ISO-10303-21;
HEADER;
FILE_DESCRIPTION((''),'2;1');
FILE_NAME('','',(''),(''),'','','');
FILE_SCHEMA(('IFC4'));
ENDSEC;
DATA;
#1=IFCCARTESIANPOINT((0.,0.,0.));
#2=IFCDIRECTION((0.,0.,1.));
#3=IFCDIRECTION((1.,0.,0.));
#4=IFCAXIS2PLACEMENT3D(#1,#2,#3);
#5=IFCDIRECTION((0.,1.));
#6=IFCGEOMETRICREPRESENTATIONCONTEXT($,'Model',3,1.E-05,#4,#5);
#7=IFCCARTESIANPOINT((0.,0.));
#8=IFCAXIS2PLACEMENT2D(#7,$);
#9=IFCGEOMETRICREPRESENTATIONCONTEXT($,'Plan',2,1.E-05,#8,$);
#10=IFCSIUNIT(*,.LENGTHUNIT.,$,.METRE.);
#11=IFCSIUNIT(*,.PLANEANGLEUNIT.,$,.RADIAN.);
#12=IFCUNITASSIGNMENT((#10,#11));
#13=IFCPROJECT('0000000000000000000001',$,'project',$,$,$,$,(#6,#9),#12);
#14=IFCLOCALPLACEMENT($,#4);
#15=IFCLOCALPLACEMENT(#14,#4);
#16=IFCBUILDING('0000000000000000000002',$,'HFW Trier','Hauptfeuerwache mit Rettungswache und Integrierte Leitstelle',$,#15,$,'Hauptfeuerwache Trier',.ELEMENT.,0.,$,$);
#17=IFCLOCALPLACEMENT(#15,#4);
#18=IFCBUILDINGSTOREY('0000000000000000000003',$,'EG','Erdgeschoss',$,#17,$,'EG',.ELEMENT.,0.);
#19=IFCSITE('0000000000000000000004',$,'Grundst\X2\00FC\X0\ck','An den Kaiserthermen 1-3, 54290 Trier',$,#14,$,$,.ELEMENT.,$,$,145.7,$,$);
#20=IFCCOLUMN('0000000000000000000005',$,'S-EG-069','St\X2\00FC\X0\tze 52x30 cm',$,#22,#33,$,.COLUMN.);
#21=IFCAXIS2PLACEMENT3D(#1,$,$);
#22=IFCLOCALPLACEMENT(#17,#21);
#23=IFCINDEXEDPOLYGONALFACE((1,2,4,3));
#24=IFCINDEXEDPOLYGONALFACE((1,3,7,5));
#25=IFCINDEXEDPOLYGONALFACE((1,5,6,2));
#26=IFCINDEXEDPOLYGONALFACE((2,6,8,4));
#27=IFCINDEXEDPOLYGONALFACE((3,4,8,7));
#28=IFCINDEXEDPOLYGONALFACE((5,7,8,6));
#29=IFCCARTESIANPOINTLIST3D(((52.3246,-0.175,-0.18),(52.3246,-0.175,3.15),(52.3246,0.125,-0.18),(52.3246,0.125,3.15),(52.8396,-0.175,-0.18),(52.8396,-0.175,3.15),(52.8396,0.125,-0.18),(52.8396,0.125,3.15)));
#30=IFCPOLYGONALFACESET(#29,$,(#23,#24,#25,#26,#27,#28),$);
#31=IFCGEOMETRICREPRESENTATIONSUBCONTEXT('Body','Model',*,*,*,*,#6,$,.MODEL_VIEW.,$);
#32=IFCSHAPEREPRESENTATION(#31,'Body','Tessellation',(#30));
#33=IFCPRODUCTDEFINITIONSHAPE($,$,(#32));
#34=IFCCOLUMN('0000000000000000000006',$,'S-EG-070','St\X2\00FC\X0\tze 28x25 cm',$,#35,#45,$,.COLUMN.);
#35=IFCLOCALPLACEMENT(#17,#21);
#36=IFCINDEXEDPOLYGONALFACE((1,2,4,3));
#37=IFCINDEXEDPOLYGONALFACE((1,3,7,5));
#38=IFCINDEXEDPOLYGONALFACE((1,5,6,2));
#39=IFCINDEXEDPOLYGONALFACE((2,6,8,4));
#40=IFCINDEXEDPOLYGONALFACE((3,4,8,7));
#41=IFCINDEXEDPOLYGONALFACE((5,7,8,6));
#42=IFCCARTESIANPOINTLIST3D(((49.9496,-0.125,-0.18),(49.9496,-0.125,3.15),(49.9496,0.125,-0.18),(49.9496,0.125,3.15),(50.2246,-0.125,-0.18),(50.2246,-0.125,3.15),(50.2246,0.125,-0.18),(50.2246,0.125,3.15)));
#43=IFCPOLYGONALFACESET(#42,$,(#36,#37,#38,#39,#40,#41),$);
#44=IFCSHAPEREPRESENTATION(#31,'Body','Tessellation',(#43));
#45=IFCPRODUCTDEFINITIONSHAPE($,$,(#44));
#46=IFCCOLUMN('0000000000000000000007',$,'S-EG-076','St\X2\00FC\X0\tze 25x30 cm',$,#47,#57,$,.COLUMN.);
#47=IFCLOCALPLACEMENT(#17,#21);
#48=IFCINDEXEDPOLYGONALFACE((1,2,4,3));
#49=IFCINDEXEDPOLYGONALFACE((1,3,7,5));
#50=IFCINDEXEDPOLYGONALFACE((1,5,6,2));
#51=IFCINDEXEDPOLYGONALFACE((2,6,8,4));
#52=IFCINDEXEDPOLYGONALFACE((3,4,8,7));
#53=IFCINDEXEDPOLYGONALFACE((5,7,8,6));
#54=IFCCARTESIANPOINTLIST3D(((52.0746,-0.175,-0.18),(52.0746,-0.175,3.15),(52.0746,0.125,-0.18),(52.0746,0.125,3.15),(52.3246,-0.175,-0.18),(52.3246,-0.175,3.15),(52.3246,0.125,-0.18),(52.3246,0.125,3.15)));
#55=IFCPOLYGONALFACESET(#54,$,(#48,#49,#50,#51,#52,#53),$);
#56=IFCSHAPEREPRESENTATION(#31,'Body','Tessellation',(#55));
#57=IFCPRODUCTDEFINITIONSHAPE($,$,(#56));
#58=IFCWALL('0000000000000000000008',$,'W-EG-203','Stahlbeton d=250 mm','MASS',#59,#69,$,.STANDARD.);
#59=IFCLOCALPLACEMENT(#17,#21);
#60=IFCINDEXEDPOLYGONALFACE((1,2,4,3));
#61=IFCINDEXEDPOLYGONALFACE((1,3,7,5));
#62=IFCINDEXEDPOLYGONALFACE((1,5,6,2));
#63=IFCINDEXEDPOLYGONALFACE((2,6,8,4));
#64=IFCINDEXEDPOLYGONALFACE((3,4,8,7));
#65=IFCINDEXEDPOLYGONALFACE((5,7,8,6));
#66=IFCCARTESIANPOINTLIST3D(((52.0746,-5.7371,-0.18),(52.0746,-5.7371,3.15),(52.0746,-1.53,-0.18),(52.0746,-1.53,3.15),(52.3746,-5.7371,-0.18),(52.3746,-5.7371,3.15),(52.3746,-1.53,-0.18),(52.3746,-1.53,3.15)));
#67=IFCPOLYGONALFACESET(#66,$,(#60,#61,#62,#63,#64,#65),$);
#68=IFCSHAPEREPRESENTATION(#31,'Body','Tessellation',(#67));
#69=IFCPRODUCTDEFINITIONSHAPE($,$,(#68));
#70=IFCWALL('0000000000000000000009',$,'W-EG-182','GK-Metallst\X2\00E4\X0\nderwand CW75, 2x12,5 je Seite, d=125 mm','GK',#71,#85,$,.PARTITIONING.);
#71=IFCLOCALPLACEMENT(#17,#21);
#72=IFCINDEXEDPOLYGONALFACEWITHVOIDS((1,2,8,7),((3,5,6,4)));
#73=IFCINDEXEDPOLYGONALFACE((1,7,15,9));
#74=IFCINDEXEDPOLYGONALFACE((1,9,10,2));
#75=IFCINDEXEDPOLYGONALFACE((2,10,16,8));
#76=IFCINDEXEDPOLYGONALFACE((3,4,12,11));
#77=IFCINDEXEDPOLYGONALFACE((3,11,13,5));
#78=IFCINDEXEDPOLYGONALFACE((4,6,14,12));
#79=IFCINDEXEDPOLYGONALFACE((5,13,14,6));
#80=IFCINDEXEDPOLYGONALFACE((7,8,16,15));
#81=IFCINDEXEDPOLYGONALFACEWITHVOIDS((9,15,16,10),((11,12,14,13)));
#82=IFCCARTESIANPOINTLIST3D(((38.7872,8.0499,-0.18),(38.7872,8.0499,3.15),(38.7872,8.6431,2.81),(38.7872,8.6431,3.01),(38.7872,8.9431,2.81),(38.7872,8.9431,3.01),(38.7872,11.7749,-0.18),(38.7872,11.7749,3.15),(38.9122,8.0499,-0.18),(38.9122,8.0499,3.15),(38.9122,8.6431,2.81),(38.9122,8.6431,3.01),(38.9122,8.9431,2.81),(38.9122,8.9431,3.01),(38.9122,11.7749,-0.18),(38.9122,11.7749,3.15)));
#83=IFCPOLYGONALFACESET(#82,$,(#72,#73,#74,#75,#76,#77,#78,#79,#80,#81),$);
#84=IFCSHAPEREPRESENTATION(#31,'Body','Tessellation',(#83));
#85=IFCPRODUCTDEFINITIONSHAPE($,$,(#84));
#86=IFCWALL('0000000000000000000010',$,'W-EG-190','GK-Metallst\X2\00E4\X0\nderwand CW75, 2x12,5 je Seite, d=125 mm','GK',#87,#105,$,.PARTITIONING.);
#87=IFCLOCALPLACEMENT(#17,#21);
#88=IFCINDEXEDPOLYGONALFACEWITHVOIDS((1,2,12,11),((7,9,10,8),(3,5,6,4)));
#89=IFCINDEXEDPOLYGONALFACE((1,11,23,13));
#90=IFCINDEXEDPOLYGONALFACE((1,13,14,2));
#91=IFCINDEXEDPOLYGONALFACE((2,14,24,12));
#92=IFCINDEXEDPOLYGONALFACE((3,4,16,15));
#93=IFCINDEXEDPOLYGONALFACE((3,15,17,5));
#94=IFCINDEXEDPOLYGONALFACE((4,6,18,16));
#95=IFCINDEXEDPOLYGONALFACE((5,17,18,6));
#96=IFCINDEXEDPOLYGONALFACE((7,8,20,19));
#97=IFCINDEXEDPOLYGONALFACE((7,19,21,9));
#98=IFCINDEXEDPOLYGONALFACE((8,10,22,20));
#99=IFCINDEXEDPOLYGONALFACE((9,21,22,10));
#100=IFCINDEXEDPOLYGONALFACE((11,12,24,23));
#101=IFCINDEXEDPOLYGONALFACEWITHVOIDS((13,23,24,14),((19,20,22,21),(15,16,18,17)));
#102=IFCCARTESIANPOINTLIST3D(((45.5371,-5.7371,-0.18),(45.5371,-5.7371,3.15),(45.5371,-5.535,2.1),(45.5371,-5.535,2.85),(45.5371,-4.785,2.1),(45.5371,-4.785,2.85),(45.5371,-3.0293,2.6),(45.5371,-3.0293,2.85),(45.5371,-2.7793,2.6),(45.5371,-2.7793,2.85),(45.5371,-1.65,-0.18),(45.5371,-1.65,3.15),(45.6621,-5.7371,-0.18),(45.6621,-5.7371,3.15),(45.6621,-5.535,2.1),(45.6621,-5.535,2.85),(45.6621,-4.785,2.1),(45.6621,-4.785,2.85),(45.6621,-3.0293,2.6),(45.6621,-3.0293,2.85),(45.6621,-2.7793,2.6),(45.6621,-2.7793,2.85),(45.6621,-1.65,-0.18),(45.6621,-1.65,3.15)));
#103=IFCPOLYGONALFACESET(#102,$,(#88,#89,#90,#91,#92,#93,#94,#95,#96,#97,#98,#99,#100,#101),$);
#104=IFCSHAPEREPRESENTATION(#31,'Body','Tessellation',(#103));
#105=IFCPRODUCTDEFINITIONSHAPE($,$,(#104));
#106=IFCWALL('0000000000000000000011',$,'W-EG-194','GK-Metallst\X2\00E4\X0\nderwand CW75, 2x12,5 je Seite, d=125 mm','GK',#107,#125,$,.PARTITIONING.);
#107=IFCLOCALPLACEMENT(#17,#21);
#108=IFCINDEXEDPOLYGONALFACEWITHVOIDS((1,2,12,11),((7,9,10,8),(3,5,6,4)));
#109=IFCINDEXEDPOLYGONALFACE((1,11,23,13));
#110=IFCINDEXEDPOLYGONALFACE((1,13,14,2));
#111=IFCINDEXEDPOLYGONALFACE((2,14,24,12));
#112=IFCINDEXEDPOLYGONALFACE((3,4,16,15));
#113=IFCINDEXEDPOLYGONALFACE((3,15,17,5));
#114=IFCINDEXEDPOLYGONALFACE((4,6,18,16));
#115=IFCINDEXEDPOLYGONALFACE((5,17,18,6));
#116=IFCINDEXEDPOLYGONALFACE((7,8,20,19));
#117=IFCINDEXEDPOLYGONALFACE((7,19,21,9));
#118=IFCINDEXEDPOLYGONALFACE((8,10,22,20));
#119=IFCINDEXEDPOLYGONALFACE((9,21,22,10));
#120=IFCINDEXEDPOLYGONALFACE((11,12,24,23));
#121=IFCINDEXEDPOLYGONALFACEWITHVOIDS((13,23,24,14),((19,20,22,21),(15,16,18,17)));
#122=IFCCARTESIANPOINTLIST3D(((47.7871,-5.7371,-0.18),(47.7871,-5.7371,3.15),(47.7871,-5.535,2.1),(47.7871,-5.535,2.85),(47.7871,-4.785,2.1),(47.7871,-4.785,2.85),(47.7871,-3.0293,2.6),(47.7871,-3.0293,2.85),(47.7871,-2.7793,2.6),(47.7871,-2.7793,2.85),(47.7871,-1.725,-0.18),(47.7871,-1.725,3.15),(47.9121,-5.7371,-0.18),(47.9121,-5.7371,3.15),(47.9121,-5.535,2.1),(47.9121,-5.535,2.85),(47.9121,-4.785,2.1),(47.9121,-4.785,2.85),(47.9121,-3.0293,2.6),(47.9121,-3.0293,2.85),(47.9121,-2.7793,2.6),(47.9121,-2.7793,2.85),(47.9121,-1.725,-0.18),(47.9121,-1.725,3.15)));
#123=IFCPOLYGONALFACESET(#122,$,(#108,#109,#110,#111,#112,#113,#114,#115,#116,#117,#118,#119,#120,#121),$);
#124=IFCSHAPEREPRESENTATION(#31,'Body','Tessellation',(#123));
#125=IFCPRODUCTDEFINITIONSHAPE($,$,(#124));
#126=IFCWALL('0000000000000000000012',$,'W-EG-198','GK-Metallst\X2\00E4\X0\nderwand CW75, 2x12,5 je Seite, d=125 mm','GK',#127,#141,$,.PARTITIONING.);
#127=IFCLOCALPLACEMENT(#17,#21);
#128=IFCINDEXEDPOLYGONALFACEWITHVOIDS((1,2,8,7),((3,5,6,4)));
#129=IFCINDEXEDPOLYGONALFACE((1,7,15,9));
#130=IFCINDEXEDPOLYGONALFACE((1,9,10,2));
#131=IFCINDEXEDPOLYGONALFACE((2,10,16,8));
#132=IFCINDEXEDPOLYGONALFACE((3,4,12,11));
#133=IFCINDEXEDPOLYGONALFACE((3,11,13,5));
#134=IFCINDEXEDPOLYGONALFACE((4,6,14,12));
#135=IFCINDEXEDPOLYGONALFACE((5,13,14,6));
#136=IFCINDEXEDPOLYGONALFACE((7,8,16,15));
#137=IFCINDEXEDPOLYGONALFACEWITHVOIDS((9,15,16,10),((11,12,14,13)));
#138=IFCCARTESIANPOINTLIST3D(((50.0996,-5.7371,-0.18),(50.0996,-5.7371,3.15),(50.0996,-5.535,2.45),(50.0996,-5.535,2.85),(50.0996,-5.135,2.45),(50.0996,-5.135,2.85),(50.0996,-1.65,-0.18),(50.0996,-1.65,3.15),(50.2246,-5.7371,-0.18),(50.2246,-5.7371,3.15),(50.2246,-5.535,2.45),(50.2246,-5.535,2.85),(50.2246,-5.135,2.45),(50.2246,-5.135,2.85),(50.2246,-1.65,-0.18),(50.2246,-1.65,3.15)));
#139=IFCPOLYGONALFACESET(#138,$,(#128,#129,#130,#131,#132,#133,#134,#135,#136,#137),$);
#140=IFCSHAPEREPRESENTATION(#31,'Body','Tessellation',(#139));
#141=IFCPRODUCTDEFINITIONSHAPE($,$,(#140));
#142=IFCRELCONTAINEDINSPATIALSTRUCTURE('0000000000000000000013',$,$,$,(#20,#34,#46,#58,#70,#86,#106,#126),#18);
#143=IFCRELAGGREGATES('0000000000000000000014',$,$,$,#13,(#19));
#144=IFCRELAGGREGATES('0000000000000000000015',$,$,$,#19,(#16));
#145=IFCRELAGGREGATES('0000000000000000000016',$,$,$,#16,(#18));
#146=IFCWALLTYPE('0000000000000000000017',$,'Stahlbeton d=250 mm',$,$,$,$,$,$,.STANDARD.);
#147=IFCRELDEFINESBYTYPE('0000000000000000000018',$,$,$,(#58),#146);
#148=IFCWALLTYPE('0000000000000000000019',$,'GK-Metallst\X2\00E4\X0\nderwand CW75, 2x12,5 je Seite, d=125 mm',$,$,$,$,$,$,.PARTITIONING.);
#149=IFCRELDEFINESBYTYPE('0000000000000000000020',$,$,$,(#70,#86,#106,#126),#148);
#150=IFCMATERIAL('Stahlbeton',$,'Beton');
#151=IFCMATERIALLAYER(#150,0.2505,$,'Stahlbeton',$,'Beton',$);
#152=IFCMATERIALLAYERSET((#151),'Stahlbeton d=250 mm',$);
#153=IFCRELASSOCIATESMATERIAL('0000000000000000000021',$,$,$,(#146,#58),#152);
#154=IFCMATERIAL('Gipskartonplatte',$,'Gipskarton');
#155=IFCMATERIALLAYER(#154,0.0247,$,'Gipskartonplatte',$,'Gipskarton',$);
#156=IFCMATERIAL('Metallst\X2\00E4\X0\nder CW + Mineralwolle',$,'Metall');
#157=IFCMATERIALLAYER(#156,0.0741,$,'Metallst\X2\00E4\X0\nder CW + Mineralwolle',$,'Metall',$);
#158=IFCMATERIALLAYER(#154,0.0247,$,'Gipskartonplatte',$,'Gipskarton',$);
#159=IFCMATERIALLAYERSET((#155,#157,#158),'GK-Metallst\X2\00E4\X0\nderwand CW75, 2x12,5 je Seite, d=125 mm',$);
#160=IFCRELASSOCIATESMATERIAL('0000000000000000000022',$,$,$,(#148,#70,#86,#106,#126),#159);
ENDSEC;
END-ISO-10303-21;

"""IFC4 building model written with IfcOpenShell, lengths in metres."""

from ifc_helpers import new_model, si_unit, direction, frame, frame_2d, origin_with_axes, origin_2d, place, context, subcontext, project, spatial, rectangle, extrude, material, layer, layer_set, layer_usage, type_object, element, save


model = new_model("IFC4")

# Units and contexts
model_context = context("Model", 3, precision=1e-05, world=origin_with_axes(), true_north=direction((0.0, 1.0)))
plan_context = context("Plan", 2, precision=1e-05, world=origin_2d())
body_context = subcontext(model_context, "Body", "Model", "MODEL_VIEW")
ifc_project = project(units=[si_unit("LENGTHUNIT", "METRE"), si_unit("PLANEANGLEUNIT", "RADIAN")], contexts=[model_context, plan_context])

# Site, building, storey
site_placement = place(None, origin_with_axes())
site = spatial("IfcSite", under=ifc_project, at=site_placement, Name="Grundstück", Description="An den Kaiserthermen 1-3, 54290 Trier", CompositionType="ELEMENT", RefElevation=145.7)
building_placement = place(site_placement, origin_with_axes())
building = spatial("IfcBuilding", under=site, at=building_placement, Name="HFW Trier", Description="Hauptfeuerwache mit Rettungswache und Integrierte Leitstelle", LongName="Hauptfeuerwache Trier", CompositionType="ELEMENT", ElevationOfRefHeight=0.0)
storey_placement = place(building_placement, origin_with_axes())
storey = spatial("IfcBuildingStorey", under=building, at=storey_placement, Name="EG", Description="Erdgeschoss", LongName="EG", CompositionType="ELEMENT", Elevation=0.0)

# Columns
column_1_placement = place(storey_placement, frame((52.3246, -0.025, -0.18), z_axis=(0.0, 0.0, 1.0), x_axis=(1.0, 0.0, 0.0)))
element("IfcColumn", 1, at=column_1_placement, inside=storey, Name="S-EG-069", Description="Stütze 52x30 cm", PredefinedType="COLUMN", context=body_context, shape_type="SweptSolid", body=[
    extrude(rectangle(XDim=0.515, YDim=0.3, at=frame_2d((0.2575, 0.0))), origin_with_axes(), (0.0, 0.0, 1.0), 3.33),
])
column_2_placement = place(storey_placement, frame((49.9496, 0.0, -0.18), z_axis=(0.0, 0.0, 1.0), x_axis=(1.0, 0.0, 0.0)))
element("IfcColumn", 2, at=column_2_placement, inside=storey, Name="S-EG-070", Description="Stütze 28x25 cm", PredefinedType="COLUMN", context=body_context, shape_type="SweptSolid", body=[
    extrude(rectangle(XDim=0.275, YDim=0.25, at=frame_2d((0.1375, 0.0))), origin_with_axes(), (0.0, 0.0, 1.0), 3.33),
])
column_3_placement = place(storey_placement, frame((52.0746, -0.025, -0.18), z_axis=(0.0, 0.0, 1.0), x_axis=(1.0, 0.0, 0.0)))
element("IfcColumn", 3, at=column_3_placement, inside=storey, Name="S-EG-076", Description="Stütze 25x30 cm", PredefinedType="COLUMN", context=body_context, shape_type="SweptSolid", body=[
    extrude(rectangle(XDim=0.25, YDim=0.3, at=frame_2d((0.125, 0.0))), origin_with_axes(), (0.0, 0.0, 1.0), 3.33),
])

# Wall
ifc_material_1 = material(Name="Stahlbeton", Category="Beton")
ifc_layer_1 = layer(ifc_material_1, 0.2505, Name="Stahlbeton", Category="Beton")
ifc_layer_set_1 = layer_set([ifc_layer_1], Name="Stahlbeton d=250 mm")
ifc_layer_usage_1 = layer_usage(ifc_layer_set_1, "AXIS2", "POSITIVE", -0.15)
wall_type_1 = type_object("IfcWallType", Name="Stahlbeton d=250 mm", PredefinedType="STANDARD", material=ifc_layer_set_1)
wall_1_placement = place(storey_placement, frame((52.2246, -1.53, -0.18), z_axis=(0.0, 0.0, 1.0), x_axis=(0.0, -1.0, 0.0)))
element("IfcWall", 4, at=wall_1_placement, inside=storey, type_object=wall_type_1, material=ifc_layer_usage_1, Name="W-EG-203", Description="Stahlbeton d=250 mm", ObjectType="MASS", PredefinedType="STANDARD", context=body_context, shape_type="SweptSolid", body=[
    extrude(rectangle(XDim=4.2071, YDim=0.3, at=frame_2d((2.1035, 0.0))), origin_with_axes(), (0.0, 0.0, 1.0), 3.33),
])

# Wall, opening
ifc_material_2 = material(Name="Gipskartonplatte", Category="Gipskarton")
ifc_layer_2 = layer(ifc_material_2, 0.0247, Name="Gipskartonplatte", Category="Gipskarton")
ifc_material_3 = material(Name="Metallständer CW + Mineralwolle", Category="Metall")
ifc_layer_3 = layer(ifc_material_3, 0.0741, Name="Metallständer CW + Mineralwolle", Category="Metall")
ifc_layer_4 = layer(ifc_material_2, 0.0247, Name="Gipskartonplatte", Category="Gipskarton")
ifc_layer_set_2 = layer_set([ifc_layer_2, ifc_layer_3, ifc_layer_4], Name="GK-Metallständerwand CW75, 2x12,5 je Seite, d=125 mm")
ifc_layer_usage_2 = layer_usage(ifc_layer_set_2, "AXIS2", "POSITIVE", -0.0625)
wall_type_2 = type_object("IfcWallType", Name="GK-Metallständerwand CW75, 2x12,5 je Seite, d=125 mm", PredefinedType="PARTITIONING", material=ifc_layer_set_2)
wall_2_placement = place(storey_placement, frame((38.8497, 11.7749, -0.18), z_axis=(0.0, 0.0, 1.0), x_axis=(0.0, -1.0, 0.0)))
wall_2 = element("IfcWall", 5, at=wall_2_placement, inside=storey, type_object=wall_type_2, material=ifc_layer_usage_2, Name="W-EG-182", Description="GK-Metallständerwand CW75, 2x12,5 je Seite, d=125 mm", ObjectType="GK", PredefinedType="PARTITIONING", context=body_context, shape_type="SweptSolid", body=[
    extrude(rectangle(XDim=3.725, YDim=0.125, at=frame_2d((1.8625, 0.0))), origin_with_axes(), (0.0, 0.0, 1.0), 3.33),
])
opening_1_placement = place(wall_2_placement, origin_with_axes())
element("IfcOpeningElement", 6, at=opening_1_placement, cuts=wall_2, ObjectType="Wanddurchbruch", PredefinedType="OPENING", context=body_context, shape_type="SweptSolid", body=[
    extrude(rectangle(XDim=0.3, YDim=0.225, at=frame_2d((2.9818, 0.0))), frame((0.0, 0.0, 2.99), z_axis=(0.0, 0.0, 1.0), x_axis=(1.0, 0.0, 0.0)), (0.0, 0.0, 1.0), 0.2),
])

# Walls, openings
ifc_layer_usage_3 = layer_usage(ifc_layer_set_2, "AXIS2", "POSITIVE", -0.0625)
wall_3_placement = place(storey_placement, frame((45.5996, -1.65, -0.18), z_axis=(0.0, 0.0, 1.0), x_axis=(0.0, -1.0, 0.0)))
wall_3 = element("IfcWall", 7, at=wall_3_placement, inside=storey, type_object=wall_type_2, material=ifc_layer_usage_3, Name="W-EG-190", Description="GK-Metallständerwand CW75, 2x12,5 je Seite, d=125 mm", ObjectType="GK", PredefinedType="PARTITIONING", context=body_context, shape_type="SweptSolid", body=[
    extrude(rectangle(XDim=4.0871, YDim=0.125, at=frame_2d((2.0435, 0.0))), origin_with_axes(), (0.0, 0.0, 1.0), 3.33),
])
opening_2_placement = place(wall_3_placement, origin_with_axes())
element("IfcOpeningElement", 8, at=opening_2_placement, cuts=wall_3, ObjectType="Wanddurchbruch", PredefinedType="OPENING", context=body_context, shape_type="SweptSolid", body=[
    extrude(rectangle(XDim=0.75, YDim=0.225, at=frame_2d((3.51, 0.0))), frame((0.0, 0.0, 2.28), z_axis=(0.0, 0.0, 1.0), x_axis=(1.0, 0.0, 0.0)), (0.0, 0.0, 1.0), 0.75),
])
opening_3_placement = place(wall_3_placement, origin_with_axes())
element("IfcOpeningElement", 9, at=opening_3_placement, cuts=wall_3, ObjectType="Wanddurchbruch", PredefinedType="OPENING", context=body_context, shape_type="SweptSolid", body=[
    extrude(rectangle(XDim=0.25, YDim=0.225, at=frame_2d((1.2543, 0.0))), frame((0.0, 0.0, 2.78), z_axis=(0.0, 0.0, 1.0), x_axis=(1.0, 0.0, 0.0)), (0.0, 0.0, 1.0), 0.25),
])
ifc_layer_usage_4 = layer_usage(ifc_layer_set_2, "AXIS2", "POSITIVE", -0.0625)
wall_4_placement = place(storey_placement, frame((47.8496, -1.725, -0.18), z_axis=(0.0, 0.0, 1.0), x_axis=(0.0, -1.0, 0.0)))
wall_4 = element("IfcWall", 10, at=wall_4_placement, inside=storey, type_object=wall_type_2, material=ifc_layer_usage_4, Name="W-EG-194", Description="GK-Metallständerwand CW75, 2x12,5 je Seite, d=125 mm", ObjectType="GK", PredefinedType="PARTITIONING", context=body_context, shape_type="SweptSolid", body=[
    extrude(rectangle(XDim=4.0121, YDim=0.125, at=frame_2d((2.0061, 0.0))), origin_with_axes(), (0.0, 0.0, 1.0), 3.33),
])
opening_4_placement = place(wall_4_placement, origin_with_axes())
element("IfcOpeningElement", 11, at=opening_4_placement, cuts=wall_4, ObjectType="Wanddurchbruch", PredefinedType="OPENING", context=body_context, shape_type="SweptSolid", body=[
    extrude(rectangle(XDim=0.75, YDim=0.225, at=frame_2d((3.435, 0.0))), frame((0.0, 0.0, 2.28), z_axis=(0.0, 0.0, 1.0), x_axis=(1.0, 0.0, 0.0)), (0.0, 0.0, 1.0), 0.75),
])
opening_5_placement = place(wall_4_placement, origin_with_axes())
element("IfcOpeningElement", 12, at=opening_5_placement, cuts=wall_4, ObjectType="Wanddurchbruch", PredefinedType="OPENING", context=body_context, shape_type="SweptSolid", body=[
    extrude(rectangle(XDim=0.25, YDim=0.225, at=frame_2d((1.1793, 0.0))), frame((0.0, 0.0, 2.78), z_axis=(0.0, 0.0, 1.0), x_axis=(1.0, 0.0, 0.0)), (0.0, 0.0, 1.0), 0.25),
])

# Wall, opening
ifc_layer_usage_5 = layer_usage(ifc_layer_set_2, "AXIS2", "POSITIVE", -0.0625)
wall_5_placement = place(storey_placement, frame((50.1621, -1.65, -0.18), z_axis=(0.0, 0.0, 1.0), x_axis=(0.0, -1.0, 0.0)))
wall_5 = element("IfcWall", 13, at=wall_5_placement, inside=storey, type_object=wall_type_2, material=ifc_layer_usage_5, Name="W-EG-198", Description="GK-Metallständerwand CW75, 2x12,5 je Seite, d=125 mm", ObjectType="GK", PredefinedType="PARTITIONING", context=body_context, shape_type="SweptSolid", body=[
    extrude(rectangle(XDim=4.0871, YDim=0.125, at=frame_2d((2.0435, 0.0))), origin_with_axes(), (0.0, 0.0, 1.0), 3.33),
])
opening_6_placement = place(wall_5_placement, origin_with_axes())
element("IfcOpeningElement", 14, at=opening_6_placement, cuts=wall_5, ObjectType="Wanddurchbruch", PredefinedType="OPENING", context=body_context, shape_type="SweptSolid", body=[
    extrude(rectangle(XDim=0.4, YDim=0.225, at=frame_2d((3.685, 0.0))), frame((0.0, 0.0, 2.63), z_axis=(0.0, 0.0, 1.0), x_axis=(1.0, 0.0, 0.0)), (0.0, 0.0, 1.0), 0.4),
])

save(model, "model.ifc")
